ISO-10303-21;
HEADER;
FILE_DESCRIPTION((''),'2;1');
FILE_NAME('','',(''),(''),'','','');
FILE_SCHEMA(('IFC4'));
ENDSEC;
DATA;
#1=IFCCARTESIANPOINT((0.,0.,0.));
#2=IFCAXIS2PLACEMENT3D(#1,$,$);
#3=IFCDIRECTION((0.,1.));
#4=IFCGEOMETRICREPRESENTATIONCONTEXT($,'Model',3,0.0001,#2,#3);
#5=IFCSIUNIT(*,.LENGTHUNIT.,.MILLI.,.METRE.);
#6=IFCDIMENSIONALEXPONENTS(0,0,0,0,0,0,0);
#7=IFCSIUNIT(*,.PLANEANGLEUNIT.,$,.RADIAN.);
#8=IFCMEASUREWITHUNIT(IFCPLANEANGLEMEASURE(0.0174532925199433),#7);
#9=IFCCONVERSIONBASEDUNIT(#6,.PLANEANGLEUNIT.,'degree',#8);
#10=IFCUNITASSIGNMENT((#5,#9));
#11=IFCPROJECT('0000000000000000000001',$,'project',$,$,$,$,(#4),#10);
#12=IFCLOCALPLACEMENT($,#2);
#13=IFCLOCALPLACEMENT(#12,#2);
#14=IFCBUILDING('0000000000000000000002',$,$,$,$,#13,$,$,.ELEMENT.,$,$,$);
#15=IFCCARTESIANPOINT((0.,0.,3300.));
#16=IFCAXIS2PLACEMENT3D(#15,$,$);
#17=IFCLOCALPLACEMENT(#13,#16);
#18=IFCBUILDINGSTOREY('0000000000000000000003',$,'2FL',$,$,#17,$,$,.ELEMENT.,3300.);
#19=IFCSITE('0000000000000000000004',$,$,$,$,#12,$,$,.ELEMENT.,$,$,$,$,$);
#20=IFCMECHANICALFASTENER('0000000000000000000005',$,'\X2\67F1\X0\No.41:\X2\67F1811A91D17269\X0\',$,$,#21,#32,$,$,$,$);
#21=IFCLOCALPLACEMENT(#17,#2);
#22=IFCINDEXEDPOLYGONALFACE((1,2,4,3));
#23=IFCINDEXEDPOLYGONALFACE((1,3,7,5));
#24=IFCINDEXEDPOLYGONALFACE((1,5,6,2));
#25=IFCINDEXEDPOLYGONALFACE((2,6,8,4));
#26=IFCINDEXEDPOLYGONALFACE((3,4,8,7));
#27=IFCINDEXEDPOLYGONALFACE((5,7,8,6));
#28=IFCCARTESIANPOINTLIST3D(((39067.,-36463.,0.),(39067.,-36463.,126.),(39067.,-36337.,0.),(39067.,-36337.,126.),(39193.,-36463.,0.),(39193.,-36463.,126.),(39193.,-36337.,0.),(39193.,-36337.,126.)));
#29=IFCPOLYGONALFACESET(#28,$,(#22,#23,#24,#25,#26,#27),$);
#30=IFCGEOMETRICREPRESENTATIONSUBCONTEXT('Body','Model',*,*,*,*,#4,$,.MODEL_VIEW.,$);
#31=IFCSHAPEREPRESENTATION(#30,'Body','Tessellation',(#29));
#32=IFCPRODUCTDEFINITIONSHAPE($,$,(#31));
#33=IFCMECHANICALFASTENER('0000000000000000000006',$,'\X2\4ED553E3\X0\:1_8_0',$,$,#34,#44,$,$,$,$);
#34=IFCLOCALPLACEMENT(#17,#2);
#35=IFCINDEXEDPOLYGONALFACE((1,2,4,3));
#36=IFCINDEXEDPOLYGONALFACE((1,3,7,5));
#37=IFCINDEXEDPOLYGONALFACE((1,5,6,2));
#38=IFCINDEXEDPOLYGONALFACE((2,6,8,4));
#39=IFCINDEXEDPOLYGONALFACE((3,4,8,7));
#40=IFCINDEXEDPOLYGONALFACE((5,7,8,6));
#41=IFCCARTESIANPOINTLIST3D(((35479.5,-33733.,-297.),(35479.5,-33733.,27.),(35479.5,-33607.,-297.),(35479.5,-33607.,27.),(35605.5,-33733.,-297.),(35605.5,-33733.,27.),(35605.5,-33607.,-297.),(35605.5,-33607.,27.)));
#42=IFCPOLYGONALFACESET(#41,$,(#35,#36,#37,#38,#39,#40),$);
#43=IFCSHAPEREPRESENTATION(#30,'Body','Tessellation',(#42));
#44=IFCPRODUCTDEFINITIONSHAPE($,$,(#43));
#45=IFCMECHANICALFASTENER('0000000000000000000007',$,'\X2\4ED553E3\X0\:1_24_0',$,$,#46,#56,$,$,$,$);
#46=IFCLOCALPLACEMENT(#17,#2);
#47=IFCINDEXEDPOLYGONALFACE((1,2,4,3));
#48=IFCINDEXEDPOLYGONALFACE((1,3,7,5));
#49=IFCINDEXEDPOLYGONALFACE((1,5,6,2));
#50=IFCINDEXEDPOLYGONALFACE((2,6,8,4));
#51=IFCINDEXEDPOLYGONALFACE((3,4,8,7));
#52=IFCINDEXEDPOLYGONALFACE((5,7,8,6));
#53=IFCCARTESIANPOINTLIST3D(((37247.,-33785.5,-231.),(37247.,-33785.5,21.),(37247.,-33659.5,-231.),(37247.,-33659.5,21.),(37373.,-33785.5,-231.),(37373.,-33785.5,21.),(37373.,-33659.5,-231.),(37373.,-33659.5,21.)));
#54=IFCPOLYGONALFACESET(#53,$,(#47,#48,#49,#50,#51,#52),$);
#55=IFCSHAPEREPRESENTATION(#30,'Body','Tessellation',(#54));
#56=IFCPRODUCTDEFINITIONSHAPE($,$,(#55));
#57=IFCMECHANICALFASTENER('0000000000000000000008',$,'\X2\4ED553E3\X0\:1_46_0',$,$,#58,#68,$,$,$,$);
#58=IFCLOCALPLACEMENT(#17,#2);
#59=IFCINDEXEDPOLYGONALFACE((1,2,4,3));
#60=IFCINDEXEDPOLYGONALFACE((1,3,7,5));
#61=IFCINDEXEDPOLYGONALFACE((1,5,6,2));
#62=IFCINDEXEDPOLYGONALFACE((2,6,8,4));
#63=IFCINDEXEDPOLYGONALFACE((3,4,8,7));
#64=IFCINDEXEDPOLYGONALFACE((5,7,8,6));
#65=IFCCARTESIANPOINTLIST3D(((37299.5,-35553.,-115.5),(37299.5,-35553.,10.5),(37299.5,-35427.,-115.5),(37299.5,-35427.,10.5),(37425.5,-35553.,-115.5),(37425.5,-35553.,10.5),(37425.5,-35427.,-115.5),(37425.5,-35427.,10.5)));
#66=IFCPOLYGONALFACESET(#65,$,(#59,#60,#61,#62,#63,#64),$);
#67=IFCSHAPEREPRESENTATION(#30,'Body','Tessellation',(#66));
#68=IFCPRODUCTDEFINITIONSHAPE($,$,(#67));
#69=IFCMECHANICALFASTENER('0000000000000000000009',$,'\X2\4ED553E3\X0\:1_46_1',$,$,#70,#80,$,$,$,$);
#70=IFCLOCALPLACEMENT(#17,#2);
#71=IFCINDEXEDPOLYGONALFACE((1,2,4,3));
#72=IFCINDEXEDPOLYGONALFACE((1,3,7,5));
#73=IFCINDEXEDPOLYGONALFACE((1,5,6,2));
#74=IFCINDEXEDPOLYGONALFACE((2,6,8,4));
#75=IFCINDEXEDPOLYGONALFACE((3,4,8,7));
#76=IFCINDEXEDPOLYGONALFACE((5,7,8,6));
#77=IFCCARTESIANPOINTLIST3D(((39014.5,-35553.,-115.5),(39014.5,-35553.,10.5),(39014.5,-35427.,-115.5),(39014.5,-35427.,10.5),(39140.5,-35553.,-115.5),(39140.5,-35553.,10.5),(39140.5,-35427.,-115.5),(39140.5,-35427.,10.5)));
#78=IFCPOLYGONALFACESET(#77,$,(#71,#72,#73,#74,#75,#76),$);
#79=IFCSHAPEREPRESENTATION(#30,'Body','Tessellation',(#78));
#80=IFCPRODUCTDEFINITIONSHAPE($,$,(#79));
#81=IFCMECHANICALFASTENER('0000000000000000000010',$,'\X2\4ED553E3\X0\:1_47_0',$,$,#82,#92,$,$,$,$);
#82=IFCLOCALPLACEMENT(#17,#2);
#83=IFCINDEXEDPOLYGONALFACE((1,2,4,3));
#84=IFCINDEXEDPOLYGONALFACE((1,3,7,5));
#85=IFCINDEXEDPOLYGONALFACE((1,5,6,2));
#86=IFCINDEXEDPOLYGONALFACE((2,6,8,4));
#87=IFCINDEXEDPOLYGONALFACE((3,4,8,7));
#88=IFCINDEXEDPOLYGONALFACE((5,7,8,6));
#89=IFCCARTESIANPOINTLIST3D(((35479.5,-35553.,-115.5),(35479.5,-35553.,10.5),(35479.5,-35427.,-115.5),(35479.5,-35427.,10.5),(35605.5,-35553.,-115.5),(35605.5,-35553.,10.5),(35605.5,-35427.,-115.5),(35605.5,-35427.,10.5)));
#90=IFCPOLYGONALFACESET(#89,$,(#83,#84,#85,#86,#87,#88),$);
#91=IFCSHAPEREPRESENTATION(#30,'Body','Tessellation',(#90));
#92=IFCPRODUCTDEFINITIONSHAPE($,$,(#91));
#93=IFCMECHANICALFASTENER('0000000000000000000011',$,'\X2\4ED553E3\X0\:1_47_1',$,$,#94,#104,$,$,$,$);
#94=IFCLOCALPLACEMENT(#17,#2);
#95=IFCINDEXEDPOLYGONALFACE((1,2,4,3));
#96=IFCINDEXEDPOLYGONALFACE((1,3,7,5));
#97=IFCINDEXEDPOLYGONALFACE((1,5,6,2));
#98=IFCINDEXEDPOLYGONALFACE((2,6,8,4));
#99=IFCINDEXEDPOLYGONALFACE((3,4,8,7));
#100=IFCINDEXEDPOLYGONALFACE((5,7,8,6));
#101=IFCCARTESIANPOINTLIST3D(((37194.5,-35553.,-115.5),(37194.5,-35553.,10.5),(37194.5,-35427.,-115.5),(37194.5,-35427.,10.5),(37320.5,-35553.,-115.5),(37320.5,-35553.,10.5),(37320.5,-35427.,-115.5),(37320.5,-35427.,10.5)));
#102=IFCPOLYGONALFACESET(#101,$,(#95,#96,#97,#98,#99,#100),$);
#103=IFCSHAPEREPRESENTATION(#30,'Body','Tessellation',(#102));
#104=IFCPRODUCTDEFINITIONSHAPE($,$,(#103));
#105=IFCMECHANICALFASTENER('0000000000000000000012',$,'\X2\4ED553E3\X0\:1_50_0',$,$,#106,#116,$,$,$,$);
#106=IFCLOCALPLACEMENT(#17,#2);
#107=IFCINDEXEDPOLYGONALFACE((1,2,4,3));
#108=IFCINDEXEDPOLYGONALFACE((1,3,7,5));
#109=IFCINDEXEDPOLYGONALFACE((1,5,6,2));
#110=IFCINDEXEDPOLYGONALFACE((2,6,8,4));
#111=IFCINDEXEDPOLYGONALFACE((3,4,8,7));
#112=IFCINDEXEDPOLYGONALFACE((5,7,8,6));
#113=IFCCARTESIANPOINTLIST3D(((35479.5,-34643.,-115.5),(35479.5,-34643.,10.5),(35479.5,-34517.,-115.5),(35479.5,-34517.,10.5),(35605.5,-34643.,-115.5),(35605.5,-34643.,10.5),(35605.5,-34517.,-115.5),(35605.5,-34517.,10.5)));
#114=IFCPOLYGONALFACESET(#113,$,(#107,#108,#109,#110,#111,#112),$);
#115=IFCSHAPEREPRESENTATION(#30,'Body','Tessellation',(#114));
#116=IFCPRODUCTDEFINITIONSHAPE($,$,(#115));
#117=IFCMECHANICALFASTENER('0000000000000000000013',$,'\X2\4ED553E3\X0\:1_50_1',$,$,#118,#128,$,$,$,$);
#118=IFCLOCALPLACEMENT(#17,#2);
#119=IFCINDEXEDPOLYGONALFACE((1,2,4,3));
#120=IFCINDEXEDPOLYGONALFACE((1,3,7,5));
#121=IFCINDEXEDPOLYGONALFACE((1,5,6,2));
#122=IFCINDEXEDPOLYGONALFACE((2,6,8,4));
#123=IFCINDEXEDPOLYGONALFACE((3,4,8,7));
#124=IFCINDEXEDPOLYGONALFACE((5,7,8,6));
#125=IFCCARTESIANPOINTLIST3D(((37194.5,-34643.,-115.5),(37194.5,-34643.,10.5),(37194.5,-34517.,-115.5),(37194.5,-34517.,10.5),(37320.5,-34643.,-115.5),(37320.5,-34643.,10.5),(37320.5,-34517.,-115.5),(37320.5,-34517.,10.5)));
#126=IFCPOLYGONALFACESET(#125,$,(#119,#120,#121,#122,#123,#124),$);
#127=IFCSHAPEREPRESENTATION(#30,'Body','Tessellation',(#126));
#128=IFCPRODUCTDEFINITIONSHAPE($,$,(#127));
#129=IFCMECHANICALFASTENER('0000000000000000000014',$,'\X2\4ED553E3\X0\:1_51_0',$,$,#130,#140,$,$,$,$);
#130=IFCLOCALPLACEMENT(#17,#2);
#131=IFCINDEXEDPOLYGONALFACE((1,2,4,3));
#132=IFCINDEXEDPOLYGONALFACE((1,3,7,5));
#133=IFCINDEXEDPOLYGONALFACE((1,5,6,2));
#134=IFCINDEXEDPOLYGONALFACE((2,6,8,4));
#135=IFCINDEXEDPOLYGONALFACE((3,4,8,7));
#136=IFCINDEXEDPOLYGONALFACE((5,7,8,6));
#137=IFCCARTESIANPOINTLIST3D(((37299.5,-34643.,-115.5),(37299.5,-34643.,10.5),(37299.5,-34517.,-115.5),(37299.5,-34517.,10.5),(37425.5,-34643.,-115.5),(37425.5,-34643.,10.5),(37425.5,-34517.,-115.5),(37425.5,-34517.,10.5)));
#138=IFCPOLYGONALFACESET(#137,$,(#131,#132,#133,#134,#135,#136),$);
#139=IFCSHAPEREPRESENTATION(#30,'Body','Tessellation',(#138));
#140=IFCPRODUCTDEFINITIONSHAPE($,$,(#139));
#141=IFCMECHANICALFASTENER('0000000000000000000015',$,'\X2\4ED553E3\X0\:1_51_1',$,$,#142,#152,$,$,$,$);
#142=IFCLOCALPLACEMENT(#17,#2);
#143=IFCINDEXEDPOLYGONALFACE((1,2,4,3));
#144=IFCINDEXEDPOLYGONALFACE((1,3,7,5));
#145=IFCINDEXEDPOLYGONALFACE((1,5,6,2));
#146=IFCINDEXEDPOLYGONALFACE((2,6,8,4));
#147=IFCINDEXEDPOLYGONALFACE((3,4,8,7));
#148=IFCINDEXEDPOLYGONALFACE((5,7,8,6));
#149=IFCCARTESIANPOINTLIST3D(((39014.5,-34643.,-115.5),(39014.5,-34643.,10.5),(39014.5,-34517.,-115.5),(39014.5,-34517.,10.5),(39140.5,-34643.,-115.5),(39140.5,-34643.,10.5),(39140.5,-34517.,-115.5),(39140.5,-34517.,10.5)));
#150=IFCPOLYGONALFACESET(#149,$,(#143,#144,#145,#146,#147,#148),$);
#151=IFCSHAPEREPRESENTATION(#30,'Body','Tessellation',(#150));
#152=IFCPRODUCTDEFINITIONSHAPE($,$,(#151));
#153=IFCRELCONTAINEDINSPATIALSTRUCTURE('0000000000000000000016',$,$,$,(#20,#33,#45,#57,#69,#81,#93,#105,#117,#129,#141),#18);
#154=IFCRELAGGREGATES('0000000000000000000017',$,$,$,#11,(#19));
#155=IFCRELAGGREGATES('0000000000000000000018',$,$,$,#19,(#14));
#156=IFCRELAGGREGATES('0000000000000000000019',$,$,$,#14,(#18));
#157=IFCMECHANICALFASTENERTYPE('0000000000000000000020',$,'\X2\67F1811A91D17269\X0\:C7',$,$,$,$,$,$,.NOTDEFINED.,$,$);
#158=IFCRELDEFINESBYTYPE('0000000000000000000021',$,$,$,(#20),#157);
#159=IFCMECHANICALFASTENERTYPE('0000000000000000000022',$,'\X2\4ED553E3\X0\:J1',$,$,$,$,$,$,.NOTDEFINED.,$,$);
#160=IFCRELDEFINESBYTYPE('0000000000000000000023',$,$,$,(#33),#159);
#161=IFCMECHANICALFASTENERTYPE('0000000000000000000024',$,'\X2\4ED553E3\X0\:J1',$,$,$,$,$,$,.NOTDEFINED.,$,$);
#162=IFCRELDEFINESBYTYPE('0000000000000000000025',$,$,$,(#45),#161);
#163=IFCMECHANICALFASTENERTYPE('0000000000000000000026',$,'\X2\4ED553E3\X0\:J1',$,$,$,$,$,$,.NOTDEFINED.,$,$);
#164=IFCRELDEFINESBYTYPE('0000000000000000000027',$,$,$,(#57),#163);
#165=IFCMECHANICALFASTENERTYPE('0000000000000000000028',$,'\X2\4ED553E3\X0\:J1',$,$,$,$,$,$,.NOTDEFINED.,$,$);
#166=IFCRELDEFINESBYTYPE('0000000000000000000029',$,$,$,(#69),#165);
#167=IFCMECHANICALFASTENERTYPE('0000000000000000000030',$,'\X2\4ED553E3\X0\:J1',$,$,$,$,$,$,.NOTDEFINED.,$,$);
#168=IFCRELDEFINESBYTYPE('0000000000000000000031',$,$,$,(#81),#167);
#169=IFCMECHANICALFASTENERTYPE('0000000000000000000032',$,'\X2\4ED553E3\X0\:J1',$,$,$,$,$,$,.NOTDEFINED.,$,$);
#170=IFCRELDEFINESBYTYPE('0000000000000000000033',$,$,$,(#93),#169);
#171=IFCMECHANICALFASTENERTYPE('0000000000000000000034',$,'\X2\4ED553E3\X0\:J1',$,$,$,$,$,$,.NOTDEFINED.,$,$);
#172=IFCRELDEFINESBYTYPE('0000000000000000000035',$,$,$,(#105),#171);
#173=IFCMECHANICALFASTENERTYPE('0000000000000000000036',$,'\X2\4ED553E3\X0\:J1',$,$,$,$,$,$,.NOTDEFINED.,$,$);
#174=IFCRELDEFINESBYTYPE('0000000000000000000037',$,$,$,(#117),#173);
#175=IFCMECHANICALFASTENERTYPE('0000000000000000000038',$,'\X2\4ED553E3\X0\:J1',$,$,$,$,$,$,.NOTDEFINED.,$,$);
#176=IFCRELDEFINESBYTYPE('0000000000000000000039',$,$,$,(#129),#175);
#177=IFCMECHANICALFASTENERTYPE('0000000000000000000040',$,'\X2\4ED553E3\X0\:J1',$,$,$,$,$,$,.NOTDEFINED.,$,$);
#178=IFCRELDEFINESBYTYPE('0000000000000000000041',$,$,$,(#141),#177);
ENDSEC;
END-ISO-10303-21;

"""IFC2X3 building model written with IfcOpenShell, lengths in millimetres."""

from ifc_helpers import new_model, entity, si_unit, converted_unit, direction, frame, origin, origin_with_axes, origin_2d, place, context, subcontext, project, spatial, rectangle, extrude, type_object, element, save


model = new_model("IFC2X3")

# Units and contexts
model_context = context("Model", 3, precision=0.0001, world=origin(), true_north=direction((0.0, 1.0)))
body_context = subcontext(model_context, "Body", "Model", "MODEL_VIEW")
ifc_project = project(units=[si_unit("LENGTHUNIT", "METRE", prefix="MILLI"), converted_unit("PLANEANGLEUNIT", "degree", entity("IfcPlaneAngleMeasure", 0.0174532925199433), si_unit("PLANEANGLEUNIT", "RADIAN"), dimensions=[0, 0, 0, 0, 0, 0, 0])], contexts=[model_context])

# Site, building, storey
site_placement = place(None, origin())
site = spatial("IfcSite", under=ifc_project, at=site_placement, CompositionType="ELEMENT")
building_placement = place(site_placement, origin())
building = spatial("IfcBuilding", under=site, at=building_placement, CompositionType="ELEMENT")
storey_placement = place(building_placement, frame((0.0, 0.0, 3300.0)))
storey = spatial("IfcBuildingStorey", under=building, at=storey_placement, Name="2FL", CompositionType="ELEMENT", Elevation=3300.0)

# Mechanical fasteners
mechanical_fastener_type_1 = type_object("IfcMechanicalFastenerType", Name="柱脚金物:C7")
mechanical_fastener_1_placement = place(storey_placement, frame((39130.0, -36400.0, 0.0)))
element("IfcMechanicalFastener", 1, at=mechanical_fastener_1_placement, inside=storey, type_object=mechanical_fastener_type_1, Name="柱No.41:柱脚金物", context=body_context, shape_type="SweptSolid", body=[
    extrude(rectangle(XDim=126.0, YDim=126.0, at=origin_2d()), origin_with_axes(), (0.0, 0.0, 1.0), 126.0),
])
mechanical_fastener_type_2 = type_object("IfcMechanicalFastenerType", Name="仕口:J1")
mechanical_fastener_2_placement = place(storey_placement, frame((35542.5, -33670.0, -297.0)))
element("IfcMechanicalFastener", 2, at=mechanical_fastener_2_placement, inside=storey, type_object=mechanical_fastener_type_2, Name="仕口:1_8_0", context=body_context, shape_type="SweptSolid", body=[
    extrude(rectangle(XDim=126.0, YDim=126.0, at=origin_2d()), origin_with_axes(), (0.0, 0.0, 1.0), 324.0),
])
mechanical_fastener_type_3 = type_object("IfcMechanicalFastenerType", Name="仕口:J1")
mechanical_fastener_3_placement = place(storey_placement, frame((37310.0, -33722.5, -231.0)))
element("IfcMechanicalFastener", 3, at=mechanical_fastener_3_placement, inside=storey, type_object=mechanical_fastener_type_3, Name="仕口:1_24_0", context=body_context, shape_type="SweptSolid", body=[
    extrude(rectangle(XDim=126.0, YDim=126.0, at=origin_2d()), origin_with_axes(), (0.0, 0.0, 1.0), 252.0),
])
mechanical_fastener_type_4 = type_object("IfcMechanicalFastenerType", Name="仕口:J1")
mechanical_fastener_4_placement = place(storey_placement, frame((37362.5, -35490.0, -115.5)))
element("IfcMechanicalFastener", 4, at=mechanical_fastener_4_placement, inside=storey, type_object=mechanical_fastener_type_4, Name="仕口:1_46_0", context=body_context, shape_type="SweptSolid", body=[
    extrude(rectangle(XDim=126.0, YDim=126.0, at=origin_2d()), origin_with_axes(), (0.0, 0.0, 1.0), 126.0),
])
mechanical_fastener_type_5 = type_object("IfcMechanicalFastenerType", Name="仕口:J1")
mechanical_fastener_5_placement = place(storey_placement, frame((39077.5, -35490.0, -115.5)))
element("IfcMechanicalFastener", 5, at=mechanical_fastener_5_placement, inside=storey, type_object=mechanical_fastener_type_5, Name="仕口:1_46_1", context=body_context, shape_type="SweptSolid", body=[
    extrude(rectangle(XDim=126.0, YDim=126.0, at=origin_2d()), origin_with_axes(), (0.0, 0.0, 1.0), 126.0),
])
mechanical_fastener_type_6 = type_object("IfcMechanicalFastenerType", Name="仕口:J1")
mechanical_fastener_6_placement = place(storey_placement, frame((35542.5, -35490.0, -115.5)))
element("IfcMechanicalFastener", 6, at=mechanical_fastener_6_placement, inside=storey, type_object=mechanical_fastener_type_6, Name="仕口:1_47_0", context=body_context, shape_type="SweptSolid", body=[
    extrude(rectangle(XDim=126.0, YDim=126.0, at=origin_2d()), origin_with_axes(), (0.0, 0.0, 1.0), 126.0),
])
mechanical_fastener_type_7 = type_object("IfcMechanicalFastenerType", Name="仕口:J1")
mechanical_fastener_7_placement = place(storey_placement, frame((37257.5, -35490.0, -115.5)))
element("IfcMechanicalFastener", 7, at=mechanical_fastener_7_placement, inside=storey, type_object=mechanical_fastener_type_7, Name="仕口:1_47_1", context=body_context, shape_type="SweptSolid", body=[
    extrude(rectangle(XDim=126.0, YDim=126.0, at=origin_2d()), origin_with_axes(), (0.0, 0.0, 1.0), 126.0),
])
mechanical_fastener_type_8 = type_object("IfcMechanicalFastenerType", Name="仕口:J1")
mechanical_fastener_8_placement = place(storey_placement, frame((35542.5, -34580.0, -115.5)))
element("IfcMechanicalFastener", 8, at=mechanical_fastener_8_placement, inside=storey, type_object=mechanical_fastener_type_8, Name="仕口:1_50_0", context=body_context, shape_type="SweptSolid", body=[
    extrude(rectangle(XDim=126.0, YDim=126.0, at=origin_2d()), origin_with_axes(), (0.0, 0.0, 1.0), 126.0),
])
mechanical_fastener_type_9 = type_object("IfcMechanicalFastenerType", Name="仕口:J1")
mechanical_fastener_9_placement = place(storey_placement, frame((37257.5, -34580.0, -115.5)))
element("IfcMechanicalFastener", 9, at=mechanical_fastener_9_placement, inside=storey, type_object=mechanical_fastener_type_9, Name="仕口:1_50_1", context=body_context, shape_type="SweptSolid", body=[
    extrude(rectangle(XDim=126.0, YDim=126.0, at=origin_2d()), origin_with_axes(), (0.0, 0.0, 1.0), 126.0),
])
mechanical_fastener_type_10 = type_object("IfcMechanicalFastenerType", Name="仕口:J1")
mechanical_fastener_10_placement = place(storey_placement, frame((37362.5, -34580.0, -115.5)))
element("IfcMechanicalFastener", 10, at=mechanical_fastener_10_placement, inside=storey, type_object=mechanical_fastener_type_10, Name="仕口:1_51_0", context=body_context, shape_type="SweptSolid", body=[
    extrude(rectangle(XDim=126.0, YDim=126.0, at=origin_2d()), origin_with_axes(), (0.0, 0.0, 1.0), 126.0),
])
mechanical_fastener_type_11 = type_object("IfcMechanicalFastenerType", Name="仕口:J1")
mechanical_fastener_11_placement = place(storey_placement, frame((39077.5, -34580.0, -115.5)))
element("IfcMechanicalFastener", 11, at=mechanical_fastener_11_placement, inside=storey, type_object=mechanical_fastener_type_11, Name="仕口:1_51_1", context=body_context, shape_type="SweptSolid", body=[
    extrude(rectangle(XDim=126.0, YDim=126.0, at=origin_2d()), origin_with_axes(), (0.0, 0.0, 1.0), 126.0),
])

save(model, "model.ifc")
